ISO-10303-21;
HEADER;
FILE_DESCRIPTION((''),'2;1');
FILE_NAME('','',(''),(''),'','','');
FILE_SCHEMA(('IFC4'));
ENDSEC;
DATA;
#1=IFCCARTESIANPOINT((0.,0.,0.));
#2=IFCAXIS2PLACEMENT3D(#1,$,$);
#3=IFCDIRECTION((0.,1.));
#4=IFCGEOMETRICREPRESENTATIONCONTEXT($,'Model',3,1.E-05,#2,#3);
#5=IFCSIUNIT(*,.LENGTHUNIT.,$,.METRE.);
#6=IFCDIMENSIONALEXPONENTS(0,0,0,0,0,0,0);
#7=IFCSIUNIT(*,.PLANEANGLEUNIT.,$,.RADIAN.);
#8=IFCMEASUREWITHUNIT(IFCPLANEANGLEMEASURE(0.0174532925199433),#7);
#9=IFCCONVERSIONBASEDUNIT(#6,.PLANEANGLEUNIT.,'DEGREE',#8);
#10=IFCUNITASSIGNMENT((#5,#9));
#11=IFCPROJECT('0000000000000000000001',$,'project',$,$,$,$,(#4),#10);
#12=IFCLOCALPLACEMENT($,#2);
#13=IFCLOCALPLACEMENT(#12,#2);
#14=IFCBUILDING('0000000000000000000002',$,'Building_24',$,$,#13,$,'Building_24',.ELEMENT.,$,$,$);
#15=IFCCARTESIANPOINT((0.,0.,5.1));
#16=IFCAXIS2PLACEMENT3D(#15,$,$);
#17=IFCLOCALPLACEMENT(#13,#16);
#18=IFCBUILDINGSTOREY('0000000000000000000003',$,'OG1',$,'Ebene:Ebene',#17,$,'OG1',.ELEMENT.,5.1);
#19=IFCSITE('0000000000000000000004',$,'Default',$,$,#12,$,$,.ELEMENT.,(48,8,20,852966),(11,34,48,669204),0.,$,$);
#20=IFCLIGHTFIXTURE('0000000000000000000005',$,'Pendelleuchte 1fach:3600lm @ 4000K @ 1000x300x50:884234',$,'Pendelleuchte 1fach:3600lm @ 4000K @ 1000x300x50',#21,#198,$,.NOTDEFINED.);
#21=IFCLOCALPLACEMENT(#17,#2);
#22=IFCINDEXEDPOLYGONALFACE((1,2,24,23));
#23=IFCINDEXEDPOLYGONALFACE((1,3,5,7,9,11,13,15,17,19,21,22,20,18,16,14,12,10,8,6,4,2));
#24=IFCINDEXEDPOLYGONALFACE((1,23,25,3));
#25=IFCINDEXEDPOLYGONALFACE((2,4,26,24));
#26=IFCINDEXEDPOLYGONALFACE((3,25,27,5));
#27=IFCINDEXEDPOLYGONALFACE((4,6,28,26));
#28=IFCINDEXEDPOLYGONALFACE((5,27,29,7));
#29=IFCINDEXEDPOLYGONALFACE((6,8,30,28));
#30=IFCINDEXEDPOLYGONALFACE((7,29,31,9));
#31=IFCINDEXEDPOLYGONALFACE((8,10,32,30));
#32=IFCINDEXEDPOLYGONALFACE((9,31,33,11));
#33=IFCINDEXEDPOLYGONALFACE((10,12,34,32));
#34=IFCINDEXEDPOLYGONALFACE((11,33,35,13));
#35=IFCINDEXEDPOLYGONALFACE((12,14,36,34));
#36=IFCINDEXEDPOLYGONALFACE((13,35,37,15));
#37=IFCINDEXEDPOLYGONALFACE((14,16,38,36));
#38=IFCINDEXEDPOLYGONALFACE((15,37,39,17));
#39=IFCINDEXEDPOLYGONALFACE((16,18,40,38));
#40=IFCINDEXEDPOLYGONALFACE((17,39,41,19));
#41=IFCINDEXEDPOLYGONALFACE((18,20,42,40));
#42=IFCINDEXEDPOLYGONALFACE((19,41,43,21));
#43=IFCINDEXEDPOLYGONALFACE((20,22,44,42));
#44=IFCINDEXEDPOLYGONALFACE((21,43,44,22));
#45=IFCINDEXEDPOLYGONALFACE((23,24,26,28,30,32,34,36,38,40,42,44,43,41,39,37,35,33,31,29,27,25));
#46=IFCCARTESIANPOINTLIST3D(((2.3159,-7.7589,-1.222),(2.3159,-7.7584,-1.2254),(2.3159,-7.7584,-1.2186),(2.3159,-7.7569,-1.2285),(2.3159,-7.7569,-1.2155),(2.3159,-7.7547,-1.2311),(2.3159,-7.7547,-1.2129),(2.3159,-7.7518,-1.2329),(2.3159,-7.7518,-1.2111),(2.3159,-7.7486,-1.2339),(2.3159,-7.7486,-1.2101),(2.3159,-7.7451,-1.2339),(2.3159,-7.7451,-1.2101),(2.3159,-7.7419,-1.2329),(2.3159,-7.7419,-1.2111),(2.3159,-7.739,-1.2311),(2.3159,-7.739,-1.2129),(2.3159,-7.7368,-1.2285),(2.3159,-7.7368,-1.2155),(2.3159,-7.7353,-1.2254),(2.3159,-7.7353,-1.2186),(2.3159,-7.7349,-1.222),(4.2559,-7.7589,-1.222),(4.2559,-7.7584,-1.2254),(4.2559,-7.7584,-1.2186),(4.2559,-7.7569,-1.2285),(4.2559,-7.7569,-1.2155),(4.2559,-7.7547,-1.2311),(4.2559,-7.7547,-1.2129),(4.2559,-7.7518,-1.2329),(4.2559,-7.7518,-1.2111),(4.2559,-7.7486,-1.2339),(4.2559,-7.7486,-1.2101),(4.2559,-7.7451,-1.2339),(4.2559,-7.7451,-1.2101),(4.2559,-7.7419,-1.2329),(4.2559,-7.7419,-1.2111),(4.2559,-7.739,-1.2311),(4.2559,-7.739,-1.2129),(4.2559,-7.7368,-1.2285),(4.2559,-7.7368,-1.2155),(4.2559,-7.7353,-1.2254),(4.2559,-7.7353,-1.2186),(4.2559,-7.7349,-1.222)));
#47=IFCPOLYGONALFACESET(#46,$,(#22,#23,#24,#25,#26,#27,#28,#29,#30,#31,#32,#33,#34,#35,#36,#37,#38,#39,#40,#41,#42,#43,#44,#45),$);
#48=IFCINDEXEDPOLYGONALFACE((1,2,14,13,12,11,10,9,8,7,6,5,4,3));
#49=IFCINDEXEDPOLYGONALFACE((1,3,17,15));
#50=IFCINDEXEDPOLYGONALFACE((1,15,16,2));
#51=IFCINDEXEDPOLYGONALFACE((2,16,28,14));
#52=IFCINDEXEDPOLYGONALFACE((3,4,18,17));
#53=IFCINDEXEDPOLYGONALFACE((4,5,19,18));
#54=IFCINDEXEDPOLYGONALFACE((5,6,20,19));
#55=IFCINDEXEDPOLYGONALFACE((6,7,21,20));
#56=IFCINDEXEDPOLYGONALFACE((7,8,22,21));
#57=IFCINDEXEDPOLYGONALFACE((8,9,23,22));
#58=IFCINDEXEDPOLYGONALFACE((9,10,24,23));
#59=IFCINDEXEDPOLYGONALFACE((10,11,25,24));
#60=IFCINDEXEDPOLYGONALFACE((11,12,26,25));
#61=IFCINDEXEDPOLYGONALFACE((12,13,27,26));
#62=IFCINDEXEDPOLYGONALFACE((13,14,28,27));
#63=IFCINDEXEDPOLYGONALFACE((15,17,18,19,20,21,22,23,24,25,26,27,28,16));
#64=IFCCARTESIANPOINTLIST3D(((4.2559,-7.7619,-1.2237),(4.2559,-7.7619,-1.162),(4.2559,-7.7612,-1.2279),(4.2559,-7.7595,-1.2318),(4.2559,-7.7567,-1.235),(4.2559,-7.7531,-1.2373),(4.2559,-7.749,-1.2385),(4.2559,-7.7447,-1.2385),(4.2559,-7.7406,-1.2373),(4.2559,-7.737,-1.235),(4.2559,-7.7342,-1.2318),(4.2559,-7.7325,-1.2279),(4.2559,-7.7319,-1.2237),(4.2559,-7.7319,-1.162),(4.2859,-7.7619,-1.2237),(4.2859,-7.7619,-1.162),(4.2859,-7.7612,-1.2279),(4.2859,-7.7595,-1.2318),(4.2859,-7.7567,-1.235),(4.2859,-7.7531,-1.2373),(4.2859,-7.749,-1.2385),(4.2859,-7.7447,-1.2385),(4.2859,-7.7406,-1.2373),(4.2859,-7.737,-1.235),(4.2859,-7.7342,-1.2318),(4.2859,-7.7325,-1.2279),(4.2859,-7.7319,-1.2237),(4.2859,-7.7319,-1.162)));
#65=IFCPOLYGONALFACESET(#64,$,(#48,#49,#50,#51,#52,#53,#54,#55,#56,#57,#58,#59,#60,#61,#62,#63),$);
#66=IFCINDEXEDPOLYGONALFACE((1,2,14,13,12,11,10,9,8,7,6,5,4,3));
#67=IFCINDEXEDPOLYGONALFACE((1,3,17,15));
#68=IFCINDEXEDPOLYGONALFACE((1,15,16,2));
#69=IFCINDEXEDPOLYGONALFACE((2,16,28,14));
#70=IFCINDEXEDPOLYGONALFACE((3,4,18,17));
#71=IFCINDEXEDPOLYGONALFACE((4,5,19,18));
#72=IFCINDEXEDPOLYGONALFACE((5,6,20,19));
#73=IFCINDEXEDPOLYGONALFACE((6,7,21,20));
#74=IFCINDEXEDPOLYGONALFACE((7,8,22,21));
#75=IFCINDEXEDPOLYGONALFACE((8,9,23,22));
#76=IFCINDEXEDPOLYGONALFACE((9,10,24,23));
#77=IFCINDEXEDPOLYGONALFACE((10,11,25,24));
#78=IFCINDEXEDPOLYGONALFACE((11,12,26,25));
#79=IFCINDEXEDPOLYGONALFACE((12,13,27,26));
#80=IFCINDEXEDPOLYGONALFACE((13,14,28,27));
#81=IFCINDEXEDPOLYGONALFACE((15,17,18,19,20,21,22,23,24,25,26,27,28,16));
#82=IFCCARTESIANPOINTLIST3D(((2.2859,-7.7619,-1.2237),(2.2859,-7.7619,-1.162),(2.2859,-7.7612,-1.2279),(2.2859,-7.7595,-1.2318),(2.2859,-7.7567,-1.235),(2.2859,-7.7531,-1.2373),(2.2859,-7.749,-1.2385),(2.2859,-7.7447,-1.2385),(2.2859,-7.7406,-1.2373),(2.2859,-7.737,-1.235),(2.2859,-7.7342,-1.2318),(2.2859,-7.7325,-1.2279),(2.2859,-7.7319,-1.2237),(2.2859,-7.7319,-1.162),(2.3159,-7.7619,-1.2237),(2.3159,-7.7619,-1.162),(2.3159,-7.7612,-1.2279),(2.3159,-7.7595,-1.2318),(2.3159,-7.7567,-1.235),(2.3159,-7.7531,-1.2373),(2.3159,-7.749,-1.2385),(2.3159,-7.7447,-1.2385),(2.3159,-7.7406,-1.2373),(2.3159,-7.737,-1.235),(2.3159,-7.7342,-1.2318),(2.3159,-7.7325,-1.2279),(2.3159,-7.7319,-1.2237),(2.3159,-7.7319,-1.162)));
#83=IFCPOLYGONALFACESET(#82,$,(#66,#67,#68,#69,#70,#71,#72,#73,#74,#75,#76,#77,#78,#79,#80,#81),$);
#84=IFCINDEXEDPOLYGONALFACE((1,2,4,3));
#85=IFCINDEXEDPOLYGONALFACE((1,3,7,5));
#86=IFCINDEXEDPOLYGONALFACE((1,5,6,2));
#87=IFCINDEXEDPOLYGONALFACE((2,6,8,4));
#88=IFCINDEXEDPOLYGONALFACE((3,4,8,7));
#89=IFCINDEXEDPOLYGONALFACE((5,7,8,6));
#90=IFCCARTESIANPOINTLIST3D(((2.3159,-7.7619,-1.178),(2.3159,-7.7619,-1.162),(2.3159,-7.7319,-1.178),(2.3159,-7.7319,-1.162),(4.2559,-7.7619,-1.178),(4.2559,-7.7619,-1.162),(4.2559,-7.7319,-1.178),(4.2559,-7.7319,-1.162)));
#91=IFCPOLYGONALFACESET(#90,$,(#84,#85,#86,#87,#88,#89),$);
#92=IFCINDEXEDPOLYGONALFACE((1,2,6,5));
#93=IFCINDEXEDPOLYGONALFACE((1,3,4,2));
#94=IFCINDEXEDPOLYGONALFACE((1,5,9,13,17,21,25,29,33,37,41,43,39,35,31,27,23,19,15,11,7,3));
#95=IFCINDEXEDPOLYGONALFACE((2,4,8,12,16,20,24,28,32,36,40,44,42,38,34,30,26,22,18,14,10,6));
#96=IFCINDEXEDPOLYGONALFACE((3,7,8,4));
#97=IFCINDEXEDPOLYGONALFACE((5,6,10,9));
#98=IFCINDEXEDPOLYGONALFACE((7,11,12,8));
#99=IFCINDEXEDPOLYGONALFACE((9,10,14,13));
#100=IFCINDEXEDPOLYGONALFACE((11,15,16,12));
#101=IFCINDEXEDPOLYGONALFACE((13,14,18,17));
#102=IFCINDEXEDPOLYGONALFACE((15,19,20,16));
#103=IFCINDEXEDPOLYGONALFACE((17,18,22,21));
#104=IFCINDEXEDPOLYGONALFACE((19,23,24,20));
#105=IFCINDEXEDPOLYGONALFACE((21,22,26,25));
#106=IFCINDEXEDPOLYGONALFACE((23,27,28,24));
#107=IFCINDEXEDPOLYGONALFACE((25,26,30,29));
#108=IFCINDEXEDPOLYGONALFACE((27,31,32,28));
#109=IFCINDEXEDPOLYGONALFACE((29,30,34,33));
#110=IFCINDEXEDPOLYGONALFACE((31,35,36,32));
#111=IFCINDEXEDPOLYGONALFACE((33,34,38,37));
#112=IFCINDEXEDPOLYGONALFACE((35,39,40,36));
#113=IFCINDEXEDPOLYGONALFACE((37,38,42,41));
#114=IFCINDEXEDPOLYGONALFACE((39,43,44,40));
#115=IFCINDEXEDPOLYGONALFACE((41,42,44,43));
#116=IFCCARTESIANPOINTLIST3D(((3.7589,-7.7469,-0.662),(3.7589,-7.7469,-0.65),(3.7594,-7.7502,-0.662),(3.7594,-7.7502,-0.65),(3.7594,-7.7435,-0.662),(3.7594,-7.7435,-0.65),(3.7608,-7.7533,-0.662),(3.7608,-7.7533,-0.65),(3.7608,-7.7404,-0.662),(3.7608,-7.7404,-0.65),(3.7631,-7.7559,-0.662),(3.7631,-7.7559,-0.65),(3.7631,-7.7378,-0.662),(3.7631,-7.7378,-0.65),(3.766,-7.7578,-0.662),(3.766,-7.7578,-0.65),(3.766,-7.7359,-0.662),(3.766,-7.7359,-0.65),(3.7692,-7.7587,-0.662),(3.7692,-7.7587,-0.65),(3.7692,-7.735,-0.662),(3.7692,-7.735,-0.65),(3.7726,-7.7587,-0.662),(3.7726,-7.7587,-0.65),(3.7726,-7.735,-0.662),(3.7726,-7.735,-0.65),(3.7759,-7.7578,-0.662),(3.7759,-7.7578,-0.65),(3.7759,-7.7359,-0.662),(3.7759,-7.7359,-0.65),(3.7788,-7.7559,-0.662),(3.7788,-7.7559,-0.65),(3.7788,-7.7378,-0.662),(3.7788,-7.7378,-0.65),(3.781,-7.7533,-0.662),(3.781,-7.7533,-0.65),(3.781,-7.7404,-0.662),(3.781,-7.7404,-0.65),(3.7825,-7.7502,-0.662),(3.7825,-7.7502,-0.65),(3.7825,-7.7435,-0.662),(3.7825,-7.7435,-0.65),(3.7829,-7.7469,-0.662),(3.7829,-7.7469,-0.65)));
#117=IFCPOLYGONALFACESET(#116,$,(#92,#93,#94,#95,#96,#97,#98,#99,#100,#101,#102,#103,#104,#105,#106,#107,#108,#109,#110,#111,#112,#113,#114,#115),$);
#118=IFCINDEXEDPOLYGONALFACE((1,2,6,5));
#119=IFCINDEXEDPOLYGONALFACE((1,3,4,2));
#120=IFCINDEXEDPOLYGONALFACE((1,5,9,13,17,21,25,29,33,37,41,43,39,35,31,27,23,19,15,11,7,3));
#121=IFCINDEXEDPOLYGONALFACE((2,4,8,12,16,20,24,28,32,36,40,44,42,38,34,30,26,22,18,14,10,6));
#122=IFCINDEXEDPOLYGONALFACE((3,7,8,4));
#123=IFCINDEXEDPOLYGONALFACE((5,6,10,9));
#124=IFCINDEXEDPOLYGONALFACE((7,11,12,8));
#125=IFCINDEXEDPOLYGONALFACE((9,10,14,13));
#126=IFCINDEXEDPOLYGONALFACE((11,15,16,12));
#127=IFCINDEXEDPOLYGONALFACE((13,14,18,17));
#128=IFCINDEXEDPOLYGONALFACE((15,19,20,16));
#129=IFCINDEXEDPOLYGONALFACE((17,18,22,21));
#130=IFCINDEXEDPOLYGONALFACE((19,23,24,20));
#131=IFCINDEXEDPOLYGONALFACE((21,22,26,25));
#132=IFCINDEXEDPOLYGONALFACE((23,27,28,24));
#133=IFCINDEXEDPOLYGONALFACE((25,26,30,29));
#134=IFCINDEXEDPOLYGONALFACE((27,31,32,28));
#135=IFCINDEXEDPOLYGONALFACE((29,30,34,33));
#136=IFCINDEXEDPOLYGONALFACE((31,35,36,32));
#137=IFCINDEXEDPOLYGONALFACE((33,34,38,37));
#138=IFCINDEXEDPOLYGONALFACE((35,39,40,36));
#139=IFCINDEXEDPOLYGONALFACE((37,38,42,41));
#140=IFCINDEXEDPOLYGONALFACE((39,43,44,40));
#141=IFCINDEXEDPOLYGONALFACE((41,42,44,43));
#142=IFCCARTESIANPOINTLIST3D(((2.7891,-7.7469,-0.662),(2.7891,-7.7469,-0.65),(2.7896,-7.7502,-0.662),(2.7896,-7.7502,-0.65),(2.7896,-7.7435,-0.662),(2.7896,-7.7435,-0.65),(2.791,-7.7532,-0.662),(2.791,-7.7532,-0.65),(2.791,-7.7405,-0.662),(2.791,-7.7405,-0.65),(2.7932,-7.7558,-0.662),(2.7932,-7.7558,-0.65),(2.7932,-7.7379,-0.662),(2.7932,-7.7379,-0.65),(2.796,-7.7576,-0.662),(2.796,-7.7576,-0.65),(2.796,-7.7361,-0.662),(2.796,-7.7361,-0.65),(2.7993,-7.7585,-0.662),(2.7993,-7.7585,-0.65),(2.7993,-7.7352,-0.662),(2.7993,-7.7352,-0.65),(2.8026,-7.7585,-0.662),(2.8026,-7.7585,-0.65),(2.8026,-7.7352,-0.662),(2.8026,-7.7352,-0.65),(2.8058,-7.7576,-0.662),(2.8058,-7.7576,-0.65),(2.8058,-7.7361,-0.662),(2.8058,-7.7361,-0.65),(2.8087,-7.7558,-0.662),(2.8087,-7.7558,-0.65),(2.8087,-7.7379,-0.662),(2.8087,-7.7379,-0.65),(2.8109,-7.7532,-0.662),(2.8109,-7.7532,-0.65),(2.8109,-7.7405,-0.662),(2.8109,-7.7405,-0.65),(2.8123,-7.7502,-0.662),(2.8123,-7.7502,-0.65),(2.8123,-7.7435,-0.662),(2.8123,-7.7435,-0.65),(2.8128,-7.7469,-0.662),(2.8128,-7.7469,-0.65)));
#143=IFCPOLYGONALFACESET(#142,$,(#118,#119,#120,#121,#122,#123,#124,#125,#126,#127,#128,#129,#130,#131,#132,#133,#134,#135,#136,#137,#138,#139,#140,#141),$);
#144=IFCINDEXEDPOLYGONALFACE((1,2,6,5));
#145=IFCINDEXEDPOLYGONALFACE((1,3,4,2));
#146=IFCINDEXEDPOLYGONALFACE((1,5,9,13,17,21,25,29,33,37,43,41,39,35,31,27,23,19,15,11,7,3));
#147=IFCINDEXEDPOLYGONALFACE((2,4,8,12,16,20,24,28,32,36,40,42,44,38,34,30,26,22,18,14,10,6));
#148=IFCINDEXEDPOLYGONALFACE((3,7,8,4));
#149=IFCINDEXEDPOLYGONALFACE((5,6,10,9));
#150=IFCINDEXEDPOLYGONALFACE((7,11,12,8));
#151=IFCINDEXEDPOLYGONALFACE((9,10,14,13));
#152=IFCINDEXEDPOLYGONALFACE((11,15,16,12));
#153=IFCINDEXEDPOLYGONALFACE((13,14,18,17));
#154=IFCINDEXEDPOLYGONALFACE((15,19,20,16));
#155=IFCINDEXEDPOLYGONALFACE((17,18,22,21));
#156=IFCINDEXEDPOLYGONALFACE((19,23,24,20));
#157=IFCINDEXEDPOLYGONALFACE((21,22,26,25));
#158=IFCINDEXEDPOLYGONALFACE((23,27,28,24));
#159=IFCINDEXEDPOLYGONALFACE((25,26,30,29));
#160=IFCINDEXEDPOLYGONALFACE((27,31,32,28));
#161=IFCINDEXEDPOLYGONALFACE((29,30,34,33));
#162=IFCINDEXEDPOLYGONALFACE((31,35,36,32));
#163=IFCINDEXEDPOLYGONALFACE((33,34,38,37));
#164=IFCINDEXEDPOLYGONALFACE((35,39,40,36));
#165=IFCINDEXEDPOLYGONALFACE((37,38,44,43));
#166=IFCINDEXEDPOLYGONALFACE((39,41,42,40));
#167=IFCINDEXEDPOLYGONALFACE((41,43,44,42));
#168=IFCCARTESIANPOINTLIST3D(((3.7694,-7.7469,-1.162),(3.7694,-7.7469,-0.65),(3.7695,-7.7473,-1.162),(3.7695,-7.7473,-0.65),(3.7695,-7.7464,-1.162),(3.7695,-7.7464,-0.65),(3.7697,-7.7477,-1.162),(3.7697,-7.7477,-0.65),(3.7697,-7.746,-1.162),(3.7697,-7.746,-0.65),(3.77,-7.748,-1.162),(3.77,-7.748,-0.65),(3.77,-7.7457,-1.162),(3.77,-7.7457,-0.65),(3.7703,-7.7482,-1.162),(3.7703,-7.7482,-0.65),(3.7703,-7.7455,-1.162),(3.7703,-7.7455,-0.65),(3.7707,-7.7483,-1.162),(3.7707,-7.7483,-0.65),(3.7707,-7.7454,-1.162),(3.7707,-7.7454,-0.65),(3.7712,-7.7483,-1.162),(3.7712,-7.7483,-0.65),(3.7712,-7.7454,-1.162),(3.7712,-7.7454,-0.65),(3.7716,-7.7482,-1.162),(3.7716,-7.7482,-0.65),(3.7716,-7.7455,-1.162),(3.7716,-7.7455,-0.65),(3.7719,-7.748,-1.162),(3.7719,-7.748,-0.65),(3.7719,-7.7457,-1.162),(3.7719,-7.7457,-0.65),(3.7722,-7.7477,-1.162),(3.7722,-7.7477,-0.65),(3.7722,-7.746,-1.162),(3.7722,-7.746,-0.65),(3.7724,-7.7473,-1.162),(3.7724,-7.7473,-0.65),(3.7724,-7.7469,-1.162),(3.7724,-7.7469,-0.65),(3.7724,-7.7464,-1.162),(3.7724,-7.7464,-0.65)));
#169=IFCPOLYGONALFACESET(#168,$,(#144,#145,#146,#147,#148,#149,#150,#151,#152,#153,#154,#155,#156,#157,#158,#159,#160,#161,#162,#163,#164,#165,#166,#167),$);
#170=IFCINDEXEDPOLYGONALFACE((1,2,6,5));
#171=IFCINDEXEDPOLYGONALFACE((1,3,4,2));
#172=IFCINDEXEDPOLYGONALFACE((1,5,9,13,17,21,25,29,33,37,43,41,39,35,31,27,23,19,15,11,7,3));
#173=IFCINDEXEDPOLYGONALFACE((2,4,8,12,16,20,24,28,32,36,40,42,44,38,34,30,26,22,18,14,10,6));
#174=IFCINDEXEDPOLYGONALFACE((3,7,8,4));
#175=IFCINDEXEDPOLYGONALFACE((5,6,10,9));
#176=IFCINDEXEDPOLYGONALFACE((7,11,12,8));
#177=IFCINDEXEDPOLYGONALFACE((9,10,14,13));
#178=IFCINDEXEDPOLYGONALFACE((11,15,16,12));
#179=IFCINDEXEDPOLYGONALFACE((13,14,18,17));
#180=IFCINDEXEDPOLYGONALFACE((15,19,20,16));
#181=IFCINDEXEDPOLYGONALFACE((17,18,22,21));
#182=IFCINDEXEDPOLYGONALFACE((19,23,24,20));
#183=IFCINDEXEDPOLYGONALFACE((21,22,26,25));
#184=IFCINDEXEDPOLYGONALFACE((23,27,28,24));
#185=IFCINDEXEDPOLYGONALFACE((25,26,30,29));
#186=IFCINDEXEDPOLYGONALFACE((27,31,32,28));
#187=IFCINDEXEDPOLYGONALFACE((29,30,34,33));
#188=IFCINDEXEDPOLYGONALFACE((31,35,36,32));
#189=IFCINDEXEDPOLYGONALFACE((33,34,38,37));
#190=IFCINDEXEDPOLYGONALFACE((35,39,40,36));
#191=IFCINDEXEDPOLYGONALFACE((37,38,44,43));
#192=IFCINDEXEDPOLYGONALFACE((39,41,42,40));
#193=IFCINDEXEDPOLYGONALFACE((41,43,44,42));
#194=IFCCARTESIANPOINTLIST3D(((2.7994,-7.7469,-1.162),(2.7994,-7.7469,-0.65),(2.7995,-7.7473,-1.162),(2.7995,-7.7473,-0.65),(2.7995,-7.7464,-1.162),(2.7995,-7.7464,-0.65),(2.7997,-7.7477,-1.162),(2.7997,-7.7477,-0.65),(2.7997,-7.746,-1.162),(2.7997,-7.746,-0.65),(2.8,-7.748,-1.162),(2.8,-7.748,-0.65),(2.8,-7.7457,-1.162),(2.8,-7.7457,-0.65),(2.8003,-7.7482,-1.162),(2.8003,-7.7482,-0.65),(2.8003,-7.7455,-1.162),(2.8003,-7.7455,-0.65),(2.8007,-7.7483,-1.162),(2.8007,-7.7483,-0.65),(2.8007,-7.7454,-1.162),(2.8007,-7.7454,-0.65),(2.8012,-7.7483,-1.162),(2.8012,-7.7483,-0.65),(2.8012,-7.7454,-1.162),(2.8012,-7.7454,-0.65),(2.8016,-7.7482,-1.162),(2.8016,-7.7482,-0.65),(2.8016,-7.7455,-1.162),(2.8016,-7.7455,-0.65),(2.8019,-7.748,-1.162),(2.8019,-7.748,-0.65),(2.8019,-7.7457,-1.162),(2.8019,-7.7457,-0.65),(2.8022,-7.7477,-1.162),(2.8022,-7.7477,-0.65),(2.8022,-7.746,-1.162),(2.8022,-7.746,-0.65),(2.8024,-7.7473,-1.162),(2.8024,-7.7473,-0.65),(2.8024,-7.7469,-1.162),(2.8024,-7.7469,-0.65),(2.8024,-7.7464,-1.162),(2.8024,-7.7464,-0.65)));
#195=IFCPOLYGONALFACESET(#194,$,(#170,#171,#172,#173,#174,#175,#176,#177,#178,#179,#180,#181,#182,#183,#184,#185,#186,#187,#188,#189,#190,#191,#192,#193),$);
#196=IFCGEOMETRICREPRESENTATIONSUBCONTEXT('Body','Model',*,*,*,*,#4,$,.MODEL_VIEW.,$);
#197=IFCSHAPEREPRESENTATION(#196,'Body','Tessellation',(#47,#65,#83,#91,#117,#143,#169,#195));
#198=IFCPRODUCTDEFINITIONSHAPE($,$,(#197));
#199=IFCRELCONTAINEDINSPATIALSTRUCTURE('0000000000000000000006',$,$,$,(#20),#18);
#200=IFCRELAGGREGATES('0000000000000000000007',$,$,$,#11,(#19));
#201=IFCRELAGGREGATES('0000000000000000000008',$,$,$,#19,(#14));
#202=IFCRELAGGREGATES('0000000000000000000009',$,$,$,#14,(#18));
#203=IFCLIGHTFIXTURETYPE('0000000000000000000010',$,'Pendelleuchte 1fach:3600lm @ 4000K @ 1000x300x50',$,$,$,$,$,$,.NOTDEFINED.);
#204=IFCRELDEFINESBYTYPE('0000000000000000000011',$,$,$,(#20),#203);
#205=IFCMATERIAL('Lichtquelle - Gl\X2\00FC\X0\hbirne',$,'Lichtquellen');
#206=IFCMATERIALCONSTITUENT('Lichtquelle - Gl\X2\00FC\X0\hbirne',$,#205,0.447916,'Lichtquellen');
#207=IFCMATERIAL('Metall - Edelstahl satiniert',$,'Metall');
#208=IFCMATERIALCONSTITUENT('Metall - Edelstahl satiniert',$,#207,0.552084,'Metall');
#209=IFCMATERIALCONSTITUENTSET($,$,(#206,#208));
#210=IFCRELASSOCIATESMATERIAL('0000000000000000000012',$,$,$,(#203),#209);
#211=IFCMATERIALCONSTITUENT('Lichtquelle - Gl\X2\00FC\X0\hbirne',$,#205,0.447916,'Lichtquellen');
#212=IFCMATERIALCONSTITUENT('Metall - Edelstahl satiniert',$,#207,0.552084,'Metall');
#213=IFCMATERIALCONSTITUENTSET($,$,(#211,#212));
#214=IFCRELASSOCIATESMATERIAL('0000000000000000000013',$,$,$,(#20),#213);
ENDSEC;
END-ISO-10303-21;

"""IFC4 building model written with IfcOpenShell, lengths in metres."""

from ifc_helpers import new_model, entity, si_unit, converted_unit, direction, frame, origin, place, context, subcontext, project, spatial, line, arc, indexed_curve, outline, extrude, source, transform, mapped, material, constituent, constituent_set, type_object, type_shapes, element, save


model = new_model("IFC4")

# Units and contexts
model_context = context("Model", 3, precision=1e-05, world=origin(), true_north=direction((0.0, 1.0)))
body_context = subcontext(model_context, "Body", "Model", "MODEL_VIEW")
ifc_project = project(units=[si_unit("LENGTHUNIT", "METRE"), converted_unit("PLANEANGLEUNIT", "DEGREE", entity("IfcPlaneAngleMeasure", 0.0174532925199433), si_unit("PLANEANGLEUNIT", "RADIAN"), dimensions=[0, 0, 0, 0, 0, 0, 0])], contexts=[model_context])

# Site, building, storey
site_placement = place(None, origin())
site = spatial("IfcSite", under=ifc_project, at=site_placement, Name="Default", CompositionType="ELEMENT", RefLatitude=(48, 8, 20, 852966), RefLongitude=(11, 34, 48, 669204), RefElevation=0.0)
building_placement = place(site_placement, origin())
building = spatial("IfcBuilding", under=site, at=building_placement, Name="Building_24", LongName="Building_24", CompositionType="ELEMENT")
storey_placement = place(building_placement, frame((0.0, 0.0, 5.1)))
storey = spatial("IfcBuildingStorey", under=building, at=storey_placement, Name="OG1", ObjectType="Ebene:Ebene", LongName="OG1", CompositionType="ELEMENT", Elevation=5.1)

# Light fixture
ifc_material_1 = material(Name="Lichtquelle - Glühbirne", Category="Lichtquellen")
ifc_material_2 = material(Name="Metall - Edelstahl satiniert", Category="Metall")
ifc_constituent_1 = constituent(ifc_material_1, Name="Lichtquelle - Glühbirne", Category="Lichtquellen", fraction=0.447916)
ifc_constituent_2 = constituent(ifc_material_2, Name="Metall - Edelstahl satiniert", Category="Metall", fraction=0.552084)
ifc_constituent_set_1 = constituent_set(constituents=[ifc_constituent_1, ifc_constituent_2])
light_fixture_type_1 = type_object("IfcLightFixtureType", Name="Pendelleuchte 1fach:3600lm @ 4000K @ 1000x300x50", PredefinedType="NOTDEFINED", material=ifc_constituent_set_1)
shared_shape_1 = source(origin(), body_context, "Body", "SweptSolid", [
    extrude(outline(indexed_curve([(-0.012, 0.0), (0.0, -0.012), (0.012, 0.0), (0.0, 0.012)], segments=[arc(1, 2, 3), arc(3, 4, 1)], self_intersect=False)), frame((-0.97, 0.0, -0.572), z_axis=(1.0, 0.0, 0.0), x_axis=(0.0, 1.0, 0.0)), (0.0, 0.0, 1.0), 1.94),
    extrude(outline(indexed_curve([(-0.0308, -0.015), (0.0308, -0.015), (0.0308, 0.015), (-0.0308, 0.015), (-0.0458, 0.0)], segments=[line(1, 2, 3, 4), arc(4, 5, 1)], self_intersect=False)), frame((0.97, 0.0, -0.5428), z_axis=(1.0, 0.0, 0.0), x_axis=(0.0, 0.0, 1.0)), (0.0, 0.0, 1.0), 0.03),
    extrude(outline(indexed_curve([(-0.0308, -0.015), (0.0308, -0.015), (0.0308, 0.015), (-0.0308, 0.015), (-0.0458, 0.0)], segments=[line(1, 2, 3, 4), arc(4, 5, 1)], self_intersect=False)), frame((-1.0, 0.0, -0.5428), z_axis=(1.0, 0.0, 0.0), x_axis=(0.0, 0.0, 1.0)), (0.0, 0.0, 1.0), 0.03),
    extrude(outline(indexed_curve([(-0.97, -0.015), (0.97, -0.015), (0.97, 0.015), (-0.97, 0.015), (-0.97, -0.015)], self_intersect=False)), frame((0.0, 0.0, -0.528), z_axis=(0.0, 0.0, 1.0), x_axis=(-1.0, 0.0, 0.0)), (0.0, 0.0, 1.0), 0.016),
    extrude(outline(indexed_curve([(-0.012, 0.0), (0.0, -0.012), (0.012, 0.0), (0.0, 0.012)], segments=[arc(1, 2, 3), arc(3, 4, 1)], self_intersect=False)), frame((0.485, 0.0, -0.012)), (0.0, 0.0, 1.0), 0.012),
    extrude(outline(indexed_curve([(-0.0118, 0.0), (0.0, -0.0118), (0.0118, 0.0), (0.0, 0.0118)], segments=[arc(1, 2, 3), arc(3, 4, 1)], self_intersect=False)), frame((-0.485, 0.0, -0.012)), (0.0, 0.0, 1.0), 0.012),
    extrude(outline(indexed_curve([(-0.0015, 0.0), (0.0, -0.0015), (0.0015, 0.0), (0.0, 0.0015)], segments=[arc(1, 2, 3), arc(3, 4, 1)], self_intersect=False)), frame((0.485, 0.0, -0.512)), (0.0, 0.0, 1.0), 0.512),
    extrude(outline(indexed_curve([(-0.0015, 0.0), (0.0, -0.0015), (0.0015, 0.0), (0.0, 0.0015)], segments=[arc(1, 2, 3), arc(3, 4, 1)], self_intersect=False)), frame((-0.485, 0.0, -0.512)), (0.0, 0.0, 1.0), 0.512),
])
type_shapes(light_fixture_type_1, [shared_shape_1])
ifc_constituent_3 = constituent(ifc_material_1, Name="Lichtquelle - Glühbirne", Category="Lichtquellen", fraction=0.447916)
ifc_constituent_4 = constituent(ifc_material_2, Name="Metall - Edelstahl satiniert", Category="Metall", fraction=0.552084)
ifc_constituent_set_2 = constituent_set(constituents=[ifc_constituent_3, ifc_constituent_4])
light_fixture_1_placement = place(storey_placement, frame((3.2859, -7.7469, -0.65)))
element("IfcLightFixture", 1, at=light_fixture_1_placement, inside=storey, type_object=light_fixture_type_1, material=ifc_constituent_set_2, Name="Pendelleuchte 1fach:3600lm @ 4000K @ 1000x300x50:884234", ObjectType="Pendelleuchte 1fach:3600lm @ 4000K @ 1000x300x50", PredefinedType="NOTDEFINED", context=body_context, shape_type="MappedRepresentation", body=[
    mapped(shared_shape_1, transform((0.0, 0.0, 0.0), scale=1.0)),
])

save(model, "model.ifc")
